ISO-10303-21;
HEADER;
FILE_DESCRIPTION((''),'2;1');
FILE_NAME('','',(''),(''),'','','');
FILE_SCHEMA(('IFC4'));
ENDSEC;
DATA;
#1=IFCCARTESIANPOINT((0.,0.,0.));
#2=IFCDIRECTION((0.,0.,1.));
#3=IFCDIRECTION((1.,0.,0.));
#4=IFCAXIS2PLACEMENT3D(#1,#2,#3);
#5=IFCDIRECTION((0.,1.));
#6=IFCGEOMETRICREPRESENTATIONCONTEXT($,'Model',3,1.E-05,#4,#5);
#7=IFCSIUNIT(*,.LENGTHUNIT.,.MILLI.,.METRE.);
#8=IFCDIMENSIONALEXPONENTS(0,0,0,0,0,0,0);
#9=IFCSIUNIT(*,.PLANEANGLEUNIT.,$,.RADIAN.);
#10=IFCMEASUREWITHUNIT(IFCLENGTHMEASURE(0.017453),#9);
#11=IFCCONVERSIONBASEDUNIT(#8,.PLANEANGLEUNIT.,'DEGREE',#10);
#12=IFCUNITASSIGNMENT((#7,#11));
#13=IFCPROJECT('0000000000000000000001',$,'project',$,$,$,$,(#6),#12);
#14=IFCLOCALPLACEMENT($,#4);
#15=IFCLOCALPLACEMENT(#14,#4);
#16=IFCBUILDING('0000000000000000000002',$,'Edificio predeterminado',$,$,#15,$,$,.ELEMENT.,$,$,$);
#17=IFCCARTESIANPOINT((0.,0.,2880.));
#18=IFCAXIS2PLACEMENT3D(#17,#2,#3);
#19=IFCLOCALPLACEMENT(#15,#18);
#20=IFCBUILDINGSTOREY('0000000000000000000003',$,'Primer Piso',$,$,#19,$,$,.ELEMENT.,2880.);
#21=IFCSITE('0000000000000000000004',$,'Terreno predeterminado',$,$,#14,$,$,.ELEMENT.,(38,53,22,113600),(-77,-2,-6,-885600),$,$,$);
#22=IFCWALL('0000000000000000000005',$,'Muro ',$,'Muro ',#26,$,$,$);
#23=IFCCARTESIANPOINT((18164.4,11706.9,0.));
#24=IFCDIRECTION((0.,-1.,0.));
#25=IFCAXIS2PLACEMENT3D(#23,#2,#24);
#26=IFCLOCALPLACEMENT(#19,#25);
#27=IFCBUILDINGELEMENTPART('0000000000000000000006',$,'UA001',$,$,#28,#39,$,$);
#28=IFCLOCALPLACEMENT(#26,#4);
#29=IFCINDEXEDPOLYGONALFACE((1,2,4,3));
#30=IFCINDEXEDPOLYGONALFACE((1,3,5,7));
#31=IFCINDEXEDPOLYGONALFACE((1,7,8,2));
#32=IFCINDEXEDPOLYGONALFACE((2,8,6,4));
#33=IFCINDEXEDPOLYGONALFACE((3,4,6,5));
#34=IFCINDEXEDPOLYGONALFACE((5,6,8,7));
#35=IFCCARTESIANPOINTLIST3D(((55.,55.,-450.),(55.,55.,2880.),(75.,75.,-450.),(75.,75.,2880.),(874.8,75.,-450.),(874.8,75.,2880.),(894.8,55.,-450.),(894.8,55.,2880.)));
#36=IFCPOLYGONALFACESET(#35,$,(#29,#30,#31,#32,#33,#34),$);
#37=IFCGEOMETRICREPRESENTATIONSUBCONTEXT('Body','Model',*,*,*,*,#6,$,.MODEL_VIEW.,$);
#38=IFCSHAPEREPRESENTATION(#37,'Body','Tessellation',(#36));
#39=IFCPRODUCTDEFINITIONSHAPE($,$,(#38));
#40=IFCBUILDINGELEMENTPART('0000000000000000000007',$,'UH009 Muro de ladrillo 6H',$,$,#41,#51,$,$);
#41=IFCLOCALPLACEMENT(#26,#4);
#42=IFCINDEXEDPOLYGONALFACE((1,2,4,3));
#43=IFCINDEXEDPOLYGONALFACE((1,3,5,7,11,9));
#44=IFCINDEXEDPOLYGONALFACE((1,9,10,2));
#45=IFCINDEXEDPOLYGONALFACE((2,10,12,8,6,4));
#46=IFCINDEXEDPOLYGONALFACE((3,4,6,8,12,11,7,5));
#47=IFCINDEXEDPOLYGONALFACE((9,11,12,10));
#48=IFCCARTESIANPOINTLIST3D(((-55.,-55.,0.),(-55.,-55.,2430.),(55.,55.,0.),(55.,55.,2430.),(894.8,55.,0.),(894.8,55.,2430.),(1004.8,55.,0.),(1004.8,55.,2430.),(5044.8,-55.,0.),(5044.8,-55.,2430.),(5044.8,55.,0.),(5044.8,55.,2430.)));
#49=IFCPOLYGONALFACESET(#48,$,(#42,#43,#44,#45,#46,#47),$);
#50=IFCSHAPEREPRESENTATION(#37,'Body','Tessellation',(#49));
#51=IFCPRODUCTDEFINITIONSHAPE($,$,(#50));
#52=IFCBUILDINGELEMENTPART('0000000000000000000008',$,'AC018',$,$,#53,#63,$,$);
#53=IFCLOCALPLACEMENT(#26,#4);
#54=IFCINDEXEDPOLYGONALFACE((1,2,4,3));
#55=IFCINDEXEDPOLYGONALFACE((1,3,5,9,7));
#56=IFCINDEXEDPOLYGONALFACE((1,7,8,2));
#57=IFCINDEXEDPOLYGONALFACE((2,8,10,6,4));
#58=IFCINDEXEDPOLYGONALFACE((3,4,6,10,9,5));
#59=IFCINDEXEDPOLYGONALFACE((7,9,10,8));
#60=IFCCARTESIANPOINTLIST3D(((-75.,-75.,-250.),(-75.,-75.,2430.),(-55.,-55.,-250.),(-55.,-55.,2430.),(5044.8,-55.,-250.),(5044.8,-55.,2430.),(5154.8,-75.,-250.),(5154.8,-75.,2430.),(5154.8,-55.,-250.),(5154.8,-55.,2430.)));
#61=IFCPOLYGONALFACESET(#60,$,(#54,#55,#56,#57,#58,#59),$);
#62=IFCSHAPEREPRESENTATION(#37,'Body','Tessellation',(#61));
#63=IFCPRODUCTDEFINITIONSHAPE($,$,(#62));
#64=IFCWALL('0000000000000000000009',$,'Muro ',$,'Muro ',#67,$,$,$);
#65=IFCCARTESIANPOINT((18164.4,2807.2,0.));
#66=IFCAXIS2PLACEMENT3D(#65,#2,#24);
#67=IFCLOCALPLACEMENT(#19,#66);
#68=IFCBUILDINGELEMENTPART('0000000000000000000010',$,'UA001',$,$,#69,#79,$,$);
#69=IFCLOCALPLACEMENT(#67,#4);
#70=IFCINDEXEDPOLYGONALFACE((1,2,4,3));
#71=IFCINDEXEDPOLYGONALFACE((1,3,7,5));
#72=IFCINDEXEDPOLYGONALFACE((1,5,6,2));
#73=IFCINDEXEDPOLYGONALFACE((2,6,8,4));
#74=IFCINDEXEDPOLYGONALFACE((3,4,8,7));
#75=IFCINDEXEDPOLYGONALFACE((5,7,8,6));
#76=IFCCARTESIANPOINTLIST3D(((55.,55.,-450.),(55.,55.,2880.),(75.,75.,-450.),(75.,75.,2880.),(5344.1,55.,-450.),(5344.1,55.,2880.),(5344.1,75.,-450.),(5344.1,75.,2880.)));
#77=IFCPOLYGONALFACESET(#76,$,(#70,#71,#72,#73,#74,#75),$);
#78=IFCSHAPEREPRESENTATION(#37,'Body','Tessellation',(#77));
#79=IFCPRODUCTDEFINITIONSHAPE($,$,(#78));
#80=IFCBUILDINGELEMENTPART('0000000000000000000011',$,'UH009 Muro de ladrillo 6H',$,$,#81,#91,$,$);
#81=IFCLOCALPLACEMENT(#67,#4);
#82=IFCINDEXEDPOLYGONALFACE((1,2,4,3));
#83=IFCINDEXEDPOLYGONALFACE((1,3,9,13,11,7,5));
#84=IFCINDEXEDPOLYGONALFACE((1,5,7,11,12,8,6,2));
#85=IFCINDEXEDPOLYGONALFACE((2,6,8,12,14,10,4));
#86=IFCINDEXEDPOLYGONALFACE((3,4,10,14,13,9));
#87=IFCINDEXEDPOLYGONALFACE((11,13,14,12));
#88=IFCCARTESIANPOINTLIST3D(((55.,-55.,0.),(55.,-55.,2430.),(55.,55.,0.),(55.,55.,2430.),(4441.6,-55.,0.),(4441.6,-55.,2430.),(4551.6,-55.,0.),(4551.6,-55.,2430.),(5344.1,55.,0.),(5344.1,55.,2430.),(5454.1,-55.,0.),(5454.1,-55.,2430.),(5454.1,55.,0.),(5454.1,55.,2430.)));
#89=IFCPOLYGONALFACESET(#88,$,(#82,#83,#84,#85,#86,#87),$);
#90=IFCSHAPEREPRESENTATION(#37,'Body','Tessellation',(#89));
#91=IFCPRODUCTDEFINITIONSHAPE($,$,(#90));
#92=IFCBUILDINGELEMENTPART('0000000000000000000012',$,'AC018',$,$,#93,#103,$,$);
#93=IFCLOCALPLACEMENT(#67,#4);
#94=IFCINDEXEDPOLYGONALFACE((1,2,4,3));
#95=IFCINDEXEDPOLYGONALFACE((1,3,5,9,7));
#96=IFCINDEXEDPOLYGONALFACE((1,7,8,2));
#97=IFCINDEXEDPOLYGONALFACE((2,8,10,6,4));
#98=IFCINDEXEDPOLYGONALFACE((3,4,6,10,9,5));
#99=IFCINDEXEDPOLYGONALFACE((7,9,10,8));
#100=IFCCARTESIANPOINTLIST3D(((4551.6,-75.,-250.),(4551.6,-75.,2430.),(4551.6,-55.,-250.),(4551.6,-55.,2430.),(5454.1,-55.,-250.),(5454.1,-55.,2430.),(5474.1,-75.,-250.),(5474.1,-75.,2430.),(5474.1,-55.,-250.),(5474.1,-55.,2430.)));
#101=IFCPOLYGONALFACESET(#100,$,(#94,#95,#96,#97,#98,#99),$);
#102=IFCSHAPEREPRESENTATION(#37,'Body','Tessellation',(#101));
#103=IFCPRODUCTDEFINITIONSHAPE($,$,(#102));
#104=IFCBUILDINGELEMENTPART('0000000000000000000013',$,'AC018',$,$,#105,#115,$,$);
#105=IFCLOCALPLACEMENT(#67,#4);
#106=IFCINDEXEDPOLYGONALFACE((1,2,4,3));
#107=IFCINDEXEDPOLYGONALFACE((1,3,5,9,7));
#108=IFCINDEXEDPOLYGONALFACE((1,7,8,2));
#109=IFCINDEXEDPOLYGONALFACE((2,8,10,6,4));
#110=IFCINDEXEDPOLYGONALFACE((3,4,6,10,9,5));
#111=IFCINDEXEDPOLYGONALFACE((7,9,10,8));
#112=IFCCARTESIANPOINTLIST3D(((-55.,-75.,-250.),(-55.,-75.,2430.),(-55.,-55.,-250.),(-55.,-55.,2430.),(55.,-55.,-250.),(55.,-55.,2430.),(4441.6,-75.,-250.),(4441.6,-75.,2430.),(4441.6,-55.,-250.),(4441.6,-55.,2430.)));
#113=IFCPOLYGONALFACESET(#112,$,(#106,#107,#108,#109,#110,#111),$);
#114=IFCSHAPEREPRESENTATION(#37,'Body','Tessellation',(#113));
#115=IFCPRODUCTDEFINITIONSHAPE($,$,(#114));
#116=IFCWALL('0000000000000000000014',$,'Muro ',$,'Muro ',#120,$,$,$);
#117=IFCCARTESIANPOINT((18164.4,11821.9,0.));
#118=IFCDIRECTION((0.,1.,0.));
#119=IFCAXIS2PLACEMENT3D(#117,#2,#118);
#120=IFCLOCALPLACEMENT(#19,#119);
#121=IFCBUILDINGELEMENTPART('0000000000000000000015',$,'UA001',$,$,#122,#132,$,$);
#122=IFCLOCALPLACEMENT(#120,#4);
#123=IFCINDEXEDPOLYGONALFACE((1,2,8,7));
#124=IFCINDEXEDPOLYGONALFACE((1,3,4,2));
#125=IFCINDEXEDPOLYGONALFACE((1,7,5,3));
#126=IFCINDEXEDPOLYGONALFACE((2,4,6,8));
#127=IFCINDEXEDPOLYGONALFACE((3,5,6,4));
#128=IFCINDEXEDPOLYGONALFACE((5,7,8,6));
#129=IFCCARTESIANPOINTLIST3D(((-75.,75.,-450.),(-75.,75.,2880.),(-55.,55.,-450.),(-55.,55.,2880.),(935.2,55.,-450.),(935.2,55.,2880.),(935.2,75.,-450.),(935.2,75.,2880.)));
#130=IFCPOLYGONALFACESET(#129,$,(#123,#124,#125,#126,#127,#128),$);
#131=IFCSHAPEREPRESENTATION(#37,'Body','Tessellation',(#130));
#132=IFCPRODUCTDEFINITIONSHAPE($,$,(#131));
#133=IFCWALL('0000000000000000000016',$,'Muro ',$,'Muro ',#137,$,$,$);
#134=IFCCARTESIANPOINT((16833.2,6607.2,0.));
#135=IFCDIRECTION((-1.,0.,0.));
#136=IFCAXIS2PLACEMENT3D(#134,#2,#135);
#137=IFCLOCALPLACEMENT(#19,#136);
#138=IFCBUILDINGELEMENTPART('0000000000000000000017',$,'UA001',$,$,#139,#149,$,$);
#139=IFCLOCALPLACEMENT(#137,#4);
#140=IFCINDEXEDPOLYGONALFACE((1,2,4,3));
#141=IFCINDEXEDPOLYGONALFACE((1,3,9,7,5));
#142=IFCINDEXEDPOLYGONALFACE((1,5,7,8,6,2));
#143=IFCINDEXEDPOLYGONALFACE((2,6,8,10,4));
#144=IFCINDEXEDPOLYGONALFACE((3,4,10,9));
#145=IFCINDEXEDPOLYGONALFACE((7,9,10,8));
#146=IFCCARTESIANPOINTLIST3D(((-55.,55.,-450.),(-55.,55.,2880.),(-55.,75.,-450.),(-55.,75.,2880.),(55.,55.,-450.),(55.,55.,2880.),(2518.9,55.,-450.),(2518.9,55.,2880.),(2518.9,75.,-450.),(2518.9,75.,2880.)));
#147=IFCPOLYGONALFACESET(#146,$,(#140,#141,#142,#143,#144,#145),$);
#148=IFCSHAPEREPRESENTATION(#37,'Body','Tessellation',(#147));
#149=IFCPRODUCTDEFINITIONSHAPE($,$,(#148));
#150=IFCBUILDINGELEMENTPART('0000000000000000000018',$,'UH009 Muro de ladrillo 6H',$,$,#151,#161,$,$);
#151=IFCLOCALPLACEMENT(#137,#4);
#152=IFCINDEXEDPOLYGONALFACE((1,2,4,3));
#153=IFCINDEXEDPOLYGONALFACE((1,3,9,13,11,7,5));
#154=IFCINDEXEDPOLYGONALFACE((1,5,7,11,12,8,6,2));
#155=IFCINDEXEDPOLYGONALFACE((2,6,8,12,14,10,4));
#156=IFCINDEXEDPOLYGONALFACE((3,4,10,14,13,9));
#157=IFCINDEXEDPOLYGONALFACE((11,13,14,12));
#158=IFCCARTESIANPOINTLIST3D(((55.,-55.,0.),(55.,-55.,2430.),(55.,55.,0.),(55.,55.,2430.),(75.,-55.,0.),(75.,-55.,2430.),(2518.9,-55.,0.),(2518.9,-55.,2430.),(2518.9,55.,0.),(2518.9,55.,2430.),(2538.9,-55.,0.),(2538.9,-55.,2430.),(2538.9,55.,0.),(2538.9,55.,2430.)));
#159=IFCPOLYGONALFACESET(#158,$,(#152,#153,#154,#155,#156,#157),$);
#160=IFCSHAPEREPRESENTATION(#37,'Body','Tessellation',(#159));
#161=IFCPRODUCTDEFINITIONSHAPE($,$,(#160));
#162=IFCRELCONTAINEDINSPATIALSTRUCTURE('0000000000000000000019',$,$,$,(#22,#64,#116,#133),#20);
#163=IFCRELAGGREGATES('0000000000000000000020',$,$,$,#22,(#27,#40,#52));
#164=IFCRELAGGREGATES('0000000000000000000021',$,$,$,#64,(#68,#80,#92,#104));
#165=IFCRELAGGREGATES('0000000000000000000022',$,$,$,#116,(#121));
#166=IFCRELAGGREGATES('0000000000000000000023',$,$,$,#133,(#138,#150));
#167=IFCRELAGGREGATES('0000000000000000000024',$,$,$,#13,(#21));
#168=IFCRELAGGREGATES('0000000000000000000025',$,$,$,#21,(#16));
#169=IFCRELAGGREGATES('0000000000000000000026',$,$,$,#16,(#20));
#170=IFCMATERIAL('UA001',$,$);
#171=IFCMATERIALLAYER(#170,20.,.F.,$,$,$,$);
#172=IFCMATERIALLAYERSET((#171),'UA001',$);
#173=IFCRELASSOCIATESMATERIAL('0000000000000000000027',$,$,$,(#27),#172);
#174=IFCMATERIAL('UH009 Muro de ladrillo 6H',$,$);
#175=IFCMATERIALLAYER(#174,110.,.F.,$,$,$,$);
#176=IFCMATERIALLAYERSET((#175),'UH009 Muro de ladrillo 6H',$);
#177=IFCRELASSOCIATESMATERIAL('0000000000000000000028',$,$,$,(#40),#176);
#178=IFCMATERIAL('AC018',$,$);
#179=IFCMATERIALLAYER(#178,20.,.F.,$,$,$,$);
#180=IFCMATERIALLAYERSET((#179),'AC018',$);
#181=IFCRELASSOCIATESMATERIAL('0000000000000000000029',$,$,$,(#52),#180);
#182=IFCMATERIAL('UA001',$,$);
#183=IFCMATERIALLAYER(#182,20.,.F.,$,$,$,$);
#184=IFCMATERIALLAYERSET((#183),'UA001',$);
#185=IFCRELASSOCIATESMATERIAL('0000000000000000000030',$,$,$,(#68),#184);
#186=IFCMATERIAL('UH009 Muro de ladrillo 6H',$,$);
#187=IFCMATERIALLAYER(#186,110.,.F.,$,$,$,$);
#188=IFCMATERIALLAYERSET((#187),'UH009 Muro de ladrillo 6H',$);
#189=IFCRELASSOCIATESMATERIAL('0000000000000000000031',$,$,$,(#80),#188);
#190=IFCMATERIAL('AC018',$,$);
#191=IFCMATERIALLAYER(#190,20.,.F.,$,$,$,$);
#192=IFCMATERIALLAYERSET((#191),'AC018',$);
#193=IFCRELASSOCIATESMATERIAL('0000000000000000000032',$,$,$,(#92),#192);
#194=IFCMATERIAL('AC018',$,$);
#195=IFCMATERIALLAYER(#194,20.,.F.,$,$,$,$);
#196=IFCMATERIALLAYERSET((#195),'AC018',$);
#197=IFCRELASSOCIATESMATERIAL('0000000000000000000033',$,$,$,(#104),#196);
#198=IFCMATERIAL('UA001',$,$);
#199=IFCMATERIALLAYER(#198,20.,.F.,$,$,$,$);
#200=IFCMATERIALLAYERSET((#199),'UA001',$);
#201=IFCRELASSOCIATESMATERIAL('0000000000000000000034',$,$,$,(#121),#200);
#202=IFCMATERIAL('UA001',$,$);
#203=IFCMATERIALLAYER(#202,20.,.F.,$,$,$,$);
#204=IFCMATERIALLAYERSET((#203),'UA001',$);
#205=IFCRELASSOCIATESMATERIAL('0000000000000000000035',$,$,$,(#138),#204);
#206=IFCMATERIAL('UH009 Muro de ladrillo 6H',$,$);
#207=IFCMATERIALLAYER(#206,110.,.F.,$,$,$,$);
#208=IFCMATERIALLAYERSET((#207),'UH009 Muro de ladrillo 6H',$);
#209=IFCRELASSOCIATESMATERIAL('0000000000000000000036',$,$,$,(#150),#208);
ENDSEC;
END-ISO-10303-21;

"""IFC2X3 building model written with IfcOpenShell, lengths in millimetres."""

from ifc_helpers import new_model, entity, si_unit, converted_unit, direction, frame, origin_with_axes, place, context, subcontext, project, spatial, polyline, outline, extrude, material, layer, layer_set, layer_usage, element, aggregate, save


model = new_model("IFC2X3")

# Units and contexts
model_context = context("Model", 3, precision=1e-05, world=origin_with_axes(), true_north=direction((0.0, 1.0)))
body_context = subcontext(model_context, "Body", "Model", "MODEL_VIEW")
ifc_project = project(units=[si_unit("LENGTHUNIT", "METRE", prefix="MILLI"), converted_unit("PLANEANGLEUNIT", "DEGREE", entity("IfcLengthMeasure", 0.017453), si_unit("PLANEANGLEUNIT", "RADIAN"), dimensions=[0, 0, 0, 0, 0, 0, 0])], contexts=[model_context])

# Site, building, storey
site_placement = place(None, origin_with_axes())
site = spatial("IfcSite", under=ifc_project, at=site_placement, Name="Terreno predeterminado", CompositionType="ELEMENT", RefLatitude=(38, 53, 22, 113600), RefLongitude=(-77, -2, -6, -885600))
building_placement = place(site_placement, origin_with_axes())
building = spatial("IfcBuilding", under=site, at=building_placement, Name="Edificio predeterminado", CompositionType="ELEMENT")
storey_placement = place(building_placement, frame((0.0, 0.0, 2880.0), z_axis=(0.0, 0.0, 1.0), x_axis=(1.0, 0.0, 0.0)))
storey = spatial("IfcBuildingStorey", under=building, at=storey_placement, Name="Primer Piso", CompositionType="ELEMENT", Elevation=2880.0)

# Walls, building element parts
wall_1_placement = place(storey_placement, frame((18164.4, 11706.9, 0.0), z_axis=(0.0, 0.0, 1.0), x_axis=(0.0, -1.0, 0.0)))
wall_1 = element("IfcWall", 1, at=wall_1_placement, inside=storey, Name="Muro ", ObjectType="Muro ")
ifc_material_1 = material(Name="UA001")
ifc_layer_1 = layer(ifc_material_1, 20.0, ventilated=False)
ifc_layer_set_1 = layer_set([ifc_layer_1], Name="UA001")
ifc_layer_usage_1 = layer_usage(ifc_layer_set_1, "AXIS2", "NEGATIVE", -75.0)
building_element_part_1_placement = place(wall_1_placement, origin_with_axes())
building_element_part_1 = element("IfcBuildingElementPart", 2, at=building_element_part_1_placement, material=ifc_layer_usage_1, Name="UA001", context=body_context, shape_type="SweptSolid", body=[
    extrude(outline(polyline([(874.8, 75.0), (894.8, 55.0), (55.0, 55.0), (75.0, 75.0), (874.8, 75.0)])), frame((0.0, 0.0, -450.0), z_axis=(0.0, 0.0, 1.0), x_axis=(1.0, 0.0, 0.0)), (0.0, 0.0, 1.0), 3330.0),
])
ifc_material_2 = material(Name="UH009 Muro de ladrillo 6H")
ifc_layer_2 = layer(ifc_material_2, 110.0, ventilated=False)
ifc_layer_set_2 = layer_set([ifc_layer_2], Name="UH009 Muro de ladrillo 6H")
ifc_layer_usage_2 = layer_usage(ifc_layer_set_2, "AXIS2", "NEGATIVE", -55.0)
building_element_part_2_placement = place(wall_1_placement, origin_with_axes())
building_element_part_2 = element("IfcBuildingElementPart", 3, at=building_element_part_2_placement, material=ifc_layer_usage_2, Name="UH009 Muro de ladrillo 6H", context=body_context, shape_type="SweptSolid", body=[
    extrude(outline(polyline([(5044.8, 55.0), (5044.8, -55.0), (-55.0, -55.0), (55.0, 55.0), (894.8, 55.0), (1004.8, 55.0), (5044.8, 55.0)])), origin_with_axes(), (0.0, 0.0, 1.0), 2430.0),
])
ifc_material_3 = material(Name="AC018")
ifc_layer_3 = layer(ifc_material_3, 20.0, ventilated=False)
ifc_layer_set_3 = layer_set([ifc_layer_3], Name="AC018")
ifc_layer_usage_3 = layer_usage(ifc_layer_set_3, "AXIS2", "NEGATIVE", 55.0)
building_element_part_3_placement = place(wall_1_placement, origin_with_axes())
building_element_part_3 = element("IfcBuildingElementPart", 4, at=building_element_part_3_placement, material=ifc_layer_usage_3, Name="AC018", context=body_context, shape_type="SweptSolid", body=[
    extrude(outline(polyline([(5154.8, -55.0), (5154.8, -75.0), (-75.0, -75.0), (-55.0, -55.0), (5044.8, -55.0), (5154.8, -55.0)])), frame((0.0, 0.0, -250.0), z_axis=(0.0, 0.0, 1.0), x_axis=(1.0, 0.0, 0.0)), (0.0, 0.0, 1.0), 2680.0),
])
aggregate(wall_1, [building_element_part_1, building_element_part_2, building_element_part_3])
wall_2_placement = place(storey_placement, frame((18164.4, 2807.2, 0.0), z_axis=(0.0, 0.0, 1.0), x_axis=(0.0, -1.0, 0.0)))
wall_2 = element("IfcWall", 5, at=wall_2_placement, inside=storey, Name="Muro ", ObjectType="Muro ")
ifc_material_4 = material(Name="UA001")
ifc_layer_4 = layer(ifc_material_4, 20.0, ventilated=False)
ifc_layer_set_4 = layer_set([ifc_layer_4], Name="UA001")
ifc_layer_usage_4 = layer_usage(ifc_layer_set_4, "AXIS2", "NEGATIVE", -75.0)
building_element_part_4_placement = place(wall_2_placement, origin_with_axes())
building_element_part_4 = element("IfcBuildingElementPart", 6, at=building_element_part_4_placement, material=ifc_layer_usage_4, Name="UA001", context=body_context, shape_type="SweptSolid", body=[
    extrude(outline(polyline([(5344.1, 75.0), (5344.1, 55.0), (55.0, 55.0), (75.0, 75.0), (5344.1, 75.0)])), frame((0.0, 0.0, -450.0), z_axis=(0.0, 0.0, 1.0), x_axis=(1.0, 0.0, 0.0)), (0.0, 0.0, 1.0), 3330.0),
])
ifc_material_5 = material(Name="UH009 Muro de ladrillo 6H")
ifc_layer_5 = layer(ifc_material_5, 110.0, ventilated=False)
ifc_layer_set_5 = layer_set([ifc_layer_5], Name="UH009 Muro de ladrillo 6H")
ifc_layer_usage_5 = layer_usage(ifc_layer_set_5, "AXIS2", "NEGATIVE", -55.0)
building_element_part_5_placement = place(wall_2_placement, origin_with_axes())
building_element_part_5 = element("IfcBuildingElementPart", 7, at=building_element_part_5_placement, material=ifc_layer_usage_5, Name="UH009 Muro de ladrillo 6H", context=body_context, shape_type="SweptSolid", body=[
    extrude(outline(polyline([(5454.1, 55.0), (5454.1, -55.0), (4551.6, -55.0), (4441.6, -55.0), (55.0, -55.0), (55.0, 55.0), (5344.1, 55.0), (5454.1, 55.0)])), origin_with_axes(), (0.0, 0.0, 1.0), 2430.0),
])
ifc_material_6 = material(Name="AC018")
ifc_layer_6 = layer(ifc_material_6, 20.0, ventilated=False)
ifc_layer_set_6 = layer_set([ifc_layer_6], Name="AC018")
ifc_layer_usage_6 = layer_usage(ifc_layer_set_6, "AXIS2", "NEGATIVE", 55.0)
building_element_part_6_placement = place(wall_2_placement, origin_with_axes())
building_element_part_6 = element("IfcBuildingElementPart", 8, at=building_element_part_6_placement, material=ifc_layer_usage_6, Name="AC018", context=body_context, shape_type="SweptSolid", body=[
    extrude(outline(polyline([(5474.1, -55.0), (5474.1, -75.0), (4551.6, -75.0), (4551.6, -55.0), (5454.1, -55.0), (5474.1, -55.0)])), frame((0.0, 0.0, -250.0), z_axis=(0.0, 0.0, 1.0), x_axis=(1.0, 0.0, 0.0)), (0.0, 0.0, 1.0), 2680.0),
])
ifc_material_7 = material(Name="AC018")
ifc_layer_7 = layer(ifc_material_7, 20.0, ventilated=False)
ifc_layer_set_7 = layer_set([ifc_layer_7], Name="AC018")
ifc_layer_usage_7 = layer_usage(ifc_layer_set_7, "AXIS2", "NEGATIVE", 55.0)
building_element_part_7_placement = place(wall_2_placement, origin_with_axes())
building_element_part_7 = element("IfcBuildingElementPart", 9, at=building_element_part_7_placement, material=ifc_layer_usage_7, Name="AC018", context=body_context, shape_type="SweptSolid", body=[
    extrude(outline(polyline([(4441.6, -55.0), (4441.6, -75.0), (-55.0, -75.0), (-55.0, -55.0), (55.0, -55.0), (4441.6, -55.0)])), frame((0.0, 0.0, -250.0), z_axis=(0.0, 0.0, 1.0), x_axis=(1.0, 0.0, 0.0)), (0.0, 0.0, 1.0), 2680.0),
])
aggregate(wall_2, [building_element_part_4, building_element_part_5, building_element_part_6, building_element_part_7])

# Wall, building element part
wall_3_placement = place(storey_placement, frame((18164.4, 11821.9, 0.0), z_axis=(0.0, 0.0, 1.0), x_axis=(0.0, 1.0, 0.0)))
wall_3 = element("IfcWall", 10, at=wall_3_placement, inside=storey, Name="Muro ", ObjectType="Muro ")
ifc_material_8 = material(Name="UA001")
ifc_layer_8 = layer(ifc_material_8, 20.0, ventilated=False)
ifc_layer_set_8 = layer_set([ifc_layer_8], Name="UA001")
ifc_layer_usage_8 = layer_usage(ifc_layer_set_8, "AXIS2", "NEGATIVE", -75.0)
building_element_part_8_placement = place(wall_3_placement, origin_with_axes())
building_element_part_8 = element("IfcBuildingElementPart", 11, at=building_element_part_8_placement, material=ifc_layer_usage_8, Name="UA001", context=body_context, shape_type="SweptSolid", body=[
    extrude(outline(polyline([(935.2, 75.0), (935.2, 55.0), (-55.0, 55.0), (-75.0, 75.0), (935.2, 75.0)])), frame((0.0, 0.0, -450.0), z_axis=(0.0, 0.0, 1.0), x_axis=(1.0, 0.0, 0.0)), (0.0, 0.0, 1.0), 3330.0),
])
aggregate(wall_3, [building_element_part_8])

# Wall, building element parts
wall_4_placement = place(storey_placement, frame((16833.2, 6607.2, 0.0), z_axis=(0.0, 0.0, 1.0), x_axis=(-1.0, 0.0, 0.0)))
wall_4 = element("IfcWall", 12, at=wall_4_placement, inside=storey, Name="Muro ", ObjectType="Muro ")
ifc_material_9 = material(Name="UA001")
ifc_layer_9 = layer(ifc_material_9, 20.0, ventilated=False)
ifc_layer_set_9 = layer_set([ifc_layer_9], Name="UA001")
ifc_layer_usage_9 = layer_usage(ifc_layer_set_9, "AXIS2", "NEGATIVE", -75.0)
building_element_part_9_placement = place(wall_4_placement, origin_with_axes())
building_element_part_9 = element("IfcBuildingElementPart", 13, at=building_element_part_9_placement, material=ifc_layer_usage_9, Name="UA001", context=body_context, shape_type="SweptSolid", body=[
    extrude(outline(polyline([(2518.9, 75.0), (2518.9, 55.0), (55.0, 55.0), (-55.0, 55.0), (-55.0, 75.0), (2518.9, 75.0)])), frame((0.0, 0.0, -450.0), z_axis=(0.0, 0.0, 1.0), x_axis=(1.0, 0.0, 0.0)), (0.0, 0.0, 1.0), 3330.0),
])
ifc_material_10 = material(Name="UH009 Muro de ladrillo 6H")
ifc_layer_10 = layer(ifc_material_10, 110.0, ventilated=False)
ifc_layer_set_10 = layer_set([ifc_layer_10], Name="UH009 Muro de ladrillo 6H")
ifc_layer_usage_10 = layer_usage(ifc_layer_set_10, "AXIS2", "NEGATIVE", -55.0)
building_element_part_10_placement = place(wall_4_placement, origin_with_axes())
building_element_part_10 = element("IfcBuildingElementPart", 14, at=building_element_part_10_placement, material=ifc_layer_usage_10, Name="UH009 Muro de ladrillo 6H", context=body_context, shape_type="SweptSolid", body=[
    extrude(outline(polyline([(2538.9, 55.0), (2538.9, -55.0), (2518.9, -55.0), (75.0, -55.0), (55.0, -55.0), (55.0, 55.0), (2518.9, 55.0), (2538.9, 55.0)])), origin_with_axes(), (0.0, 0.0, 1.0), 2430.0),
])
aggregate(wall_4, [building_element_part_9, building_element_part_10])

save(model, "model.ifc")
